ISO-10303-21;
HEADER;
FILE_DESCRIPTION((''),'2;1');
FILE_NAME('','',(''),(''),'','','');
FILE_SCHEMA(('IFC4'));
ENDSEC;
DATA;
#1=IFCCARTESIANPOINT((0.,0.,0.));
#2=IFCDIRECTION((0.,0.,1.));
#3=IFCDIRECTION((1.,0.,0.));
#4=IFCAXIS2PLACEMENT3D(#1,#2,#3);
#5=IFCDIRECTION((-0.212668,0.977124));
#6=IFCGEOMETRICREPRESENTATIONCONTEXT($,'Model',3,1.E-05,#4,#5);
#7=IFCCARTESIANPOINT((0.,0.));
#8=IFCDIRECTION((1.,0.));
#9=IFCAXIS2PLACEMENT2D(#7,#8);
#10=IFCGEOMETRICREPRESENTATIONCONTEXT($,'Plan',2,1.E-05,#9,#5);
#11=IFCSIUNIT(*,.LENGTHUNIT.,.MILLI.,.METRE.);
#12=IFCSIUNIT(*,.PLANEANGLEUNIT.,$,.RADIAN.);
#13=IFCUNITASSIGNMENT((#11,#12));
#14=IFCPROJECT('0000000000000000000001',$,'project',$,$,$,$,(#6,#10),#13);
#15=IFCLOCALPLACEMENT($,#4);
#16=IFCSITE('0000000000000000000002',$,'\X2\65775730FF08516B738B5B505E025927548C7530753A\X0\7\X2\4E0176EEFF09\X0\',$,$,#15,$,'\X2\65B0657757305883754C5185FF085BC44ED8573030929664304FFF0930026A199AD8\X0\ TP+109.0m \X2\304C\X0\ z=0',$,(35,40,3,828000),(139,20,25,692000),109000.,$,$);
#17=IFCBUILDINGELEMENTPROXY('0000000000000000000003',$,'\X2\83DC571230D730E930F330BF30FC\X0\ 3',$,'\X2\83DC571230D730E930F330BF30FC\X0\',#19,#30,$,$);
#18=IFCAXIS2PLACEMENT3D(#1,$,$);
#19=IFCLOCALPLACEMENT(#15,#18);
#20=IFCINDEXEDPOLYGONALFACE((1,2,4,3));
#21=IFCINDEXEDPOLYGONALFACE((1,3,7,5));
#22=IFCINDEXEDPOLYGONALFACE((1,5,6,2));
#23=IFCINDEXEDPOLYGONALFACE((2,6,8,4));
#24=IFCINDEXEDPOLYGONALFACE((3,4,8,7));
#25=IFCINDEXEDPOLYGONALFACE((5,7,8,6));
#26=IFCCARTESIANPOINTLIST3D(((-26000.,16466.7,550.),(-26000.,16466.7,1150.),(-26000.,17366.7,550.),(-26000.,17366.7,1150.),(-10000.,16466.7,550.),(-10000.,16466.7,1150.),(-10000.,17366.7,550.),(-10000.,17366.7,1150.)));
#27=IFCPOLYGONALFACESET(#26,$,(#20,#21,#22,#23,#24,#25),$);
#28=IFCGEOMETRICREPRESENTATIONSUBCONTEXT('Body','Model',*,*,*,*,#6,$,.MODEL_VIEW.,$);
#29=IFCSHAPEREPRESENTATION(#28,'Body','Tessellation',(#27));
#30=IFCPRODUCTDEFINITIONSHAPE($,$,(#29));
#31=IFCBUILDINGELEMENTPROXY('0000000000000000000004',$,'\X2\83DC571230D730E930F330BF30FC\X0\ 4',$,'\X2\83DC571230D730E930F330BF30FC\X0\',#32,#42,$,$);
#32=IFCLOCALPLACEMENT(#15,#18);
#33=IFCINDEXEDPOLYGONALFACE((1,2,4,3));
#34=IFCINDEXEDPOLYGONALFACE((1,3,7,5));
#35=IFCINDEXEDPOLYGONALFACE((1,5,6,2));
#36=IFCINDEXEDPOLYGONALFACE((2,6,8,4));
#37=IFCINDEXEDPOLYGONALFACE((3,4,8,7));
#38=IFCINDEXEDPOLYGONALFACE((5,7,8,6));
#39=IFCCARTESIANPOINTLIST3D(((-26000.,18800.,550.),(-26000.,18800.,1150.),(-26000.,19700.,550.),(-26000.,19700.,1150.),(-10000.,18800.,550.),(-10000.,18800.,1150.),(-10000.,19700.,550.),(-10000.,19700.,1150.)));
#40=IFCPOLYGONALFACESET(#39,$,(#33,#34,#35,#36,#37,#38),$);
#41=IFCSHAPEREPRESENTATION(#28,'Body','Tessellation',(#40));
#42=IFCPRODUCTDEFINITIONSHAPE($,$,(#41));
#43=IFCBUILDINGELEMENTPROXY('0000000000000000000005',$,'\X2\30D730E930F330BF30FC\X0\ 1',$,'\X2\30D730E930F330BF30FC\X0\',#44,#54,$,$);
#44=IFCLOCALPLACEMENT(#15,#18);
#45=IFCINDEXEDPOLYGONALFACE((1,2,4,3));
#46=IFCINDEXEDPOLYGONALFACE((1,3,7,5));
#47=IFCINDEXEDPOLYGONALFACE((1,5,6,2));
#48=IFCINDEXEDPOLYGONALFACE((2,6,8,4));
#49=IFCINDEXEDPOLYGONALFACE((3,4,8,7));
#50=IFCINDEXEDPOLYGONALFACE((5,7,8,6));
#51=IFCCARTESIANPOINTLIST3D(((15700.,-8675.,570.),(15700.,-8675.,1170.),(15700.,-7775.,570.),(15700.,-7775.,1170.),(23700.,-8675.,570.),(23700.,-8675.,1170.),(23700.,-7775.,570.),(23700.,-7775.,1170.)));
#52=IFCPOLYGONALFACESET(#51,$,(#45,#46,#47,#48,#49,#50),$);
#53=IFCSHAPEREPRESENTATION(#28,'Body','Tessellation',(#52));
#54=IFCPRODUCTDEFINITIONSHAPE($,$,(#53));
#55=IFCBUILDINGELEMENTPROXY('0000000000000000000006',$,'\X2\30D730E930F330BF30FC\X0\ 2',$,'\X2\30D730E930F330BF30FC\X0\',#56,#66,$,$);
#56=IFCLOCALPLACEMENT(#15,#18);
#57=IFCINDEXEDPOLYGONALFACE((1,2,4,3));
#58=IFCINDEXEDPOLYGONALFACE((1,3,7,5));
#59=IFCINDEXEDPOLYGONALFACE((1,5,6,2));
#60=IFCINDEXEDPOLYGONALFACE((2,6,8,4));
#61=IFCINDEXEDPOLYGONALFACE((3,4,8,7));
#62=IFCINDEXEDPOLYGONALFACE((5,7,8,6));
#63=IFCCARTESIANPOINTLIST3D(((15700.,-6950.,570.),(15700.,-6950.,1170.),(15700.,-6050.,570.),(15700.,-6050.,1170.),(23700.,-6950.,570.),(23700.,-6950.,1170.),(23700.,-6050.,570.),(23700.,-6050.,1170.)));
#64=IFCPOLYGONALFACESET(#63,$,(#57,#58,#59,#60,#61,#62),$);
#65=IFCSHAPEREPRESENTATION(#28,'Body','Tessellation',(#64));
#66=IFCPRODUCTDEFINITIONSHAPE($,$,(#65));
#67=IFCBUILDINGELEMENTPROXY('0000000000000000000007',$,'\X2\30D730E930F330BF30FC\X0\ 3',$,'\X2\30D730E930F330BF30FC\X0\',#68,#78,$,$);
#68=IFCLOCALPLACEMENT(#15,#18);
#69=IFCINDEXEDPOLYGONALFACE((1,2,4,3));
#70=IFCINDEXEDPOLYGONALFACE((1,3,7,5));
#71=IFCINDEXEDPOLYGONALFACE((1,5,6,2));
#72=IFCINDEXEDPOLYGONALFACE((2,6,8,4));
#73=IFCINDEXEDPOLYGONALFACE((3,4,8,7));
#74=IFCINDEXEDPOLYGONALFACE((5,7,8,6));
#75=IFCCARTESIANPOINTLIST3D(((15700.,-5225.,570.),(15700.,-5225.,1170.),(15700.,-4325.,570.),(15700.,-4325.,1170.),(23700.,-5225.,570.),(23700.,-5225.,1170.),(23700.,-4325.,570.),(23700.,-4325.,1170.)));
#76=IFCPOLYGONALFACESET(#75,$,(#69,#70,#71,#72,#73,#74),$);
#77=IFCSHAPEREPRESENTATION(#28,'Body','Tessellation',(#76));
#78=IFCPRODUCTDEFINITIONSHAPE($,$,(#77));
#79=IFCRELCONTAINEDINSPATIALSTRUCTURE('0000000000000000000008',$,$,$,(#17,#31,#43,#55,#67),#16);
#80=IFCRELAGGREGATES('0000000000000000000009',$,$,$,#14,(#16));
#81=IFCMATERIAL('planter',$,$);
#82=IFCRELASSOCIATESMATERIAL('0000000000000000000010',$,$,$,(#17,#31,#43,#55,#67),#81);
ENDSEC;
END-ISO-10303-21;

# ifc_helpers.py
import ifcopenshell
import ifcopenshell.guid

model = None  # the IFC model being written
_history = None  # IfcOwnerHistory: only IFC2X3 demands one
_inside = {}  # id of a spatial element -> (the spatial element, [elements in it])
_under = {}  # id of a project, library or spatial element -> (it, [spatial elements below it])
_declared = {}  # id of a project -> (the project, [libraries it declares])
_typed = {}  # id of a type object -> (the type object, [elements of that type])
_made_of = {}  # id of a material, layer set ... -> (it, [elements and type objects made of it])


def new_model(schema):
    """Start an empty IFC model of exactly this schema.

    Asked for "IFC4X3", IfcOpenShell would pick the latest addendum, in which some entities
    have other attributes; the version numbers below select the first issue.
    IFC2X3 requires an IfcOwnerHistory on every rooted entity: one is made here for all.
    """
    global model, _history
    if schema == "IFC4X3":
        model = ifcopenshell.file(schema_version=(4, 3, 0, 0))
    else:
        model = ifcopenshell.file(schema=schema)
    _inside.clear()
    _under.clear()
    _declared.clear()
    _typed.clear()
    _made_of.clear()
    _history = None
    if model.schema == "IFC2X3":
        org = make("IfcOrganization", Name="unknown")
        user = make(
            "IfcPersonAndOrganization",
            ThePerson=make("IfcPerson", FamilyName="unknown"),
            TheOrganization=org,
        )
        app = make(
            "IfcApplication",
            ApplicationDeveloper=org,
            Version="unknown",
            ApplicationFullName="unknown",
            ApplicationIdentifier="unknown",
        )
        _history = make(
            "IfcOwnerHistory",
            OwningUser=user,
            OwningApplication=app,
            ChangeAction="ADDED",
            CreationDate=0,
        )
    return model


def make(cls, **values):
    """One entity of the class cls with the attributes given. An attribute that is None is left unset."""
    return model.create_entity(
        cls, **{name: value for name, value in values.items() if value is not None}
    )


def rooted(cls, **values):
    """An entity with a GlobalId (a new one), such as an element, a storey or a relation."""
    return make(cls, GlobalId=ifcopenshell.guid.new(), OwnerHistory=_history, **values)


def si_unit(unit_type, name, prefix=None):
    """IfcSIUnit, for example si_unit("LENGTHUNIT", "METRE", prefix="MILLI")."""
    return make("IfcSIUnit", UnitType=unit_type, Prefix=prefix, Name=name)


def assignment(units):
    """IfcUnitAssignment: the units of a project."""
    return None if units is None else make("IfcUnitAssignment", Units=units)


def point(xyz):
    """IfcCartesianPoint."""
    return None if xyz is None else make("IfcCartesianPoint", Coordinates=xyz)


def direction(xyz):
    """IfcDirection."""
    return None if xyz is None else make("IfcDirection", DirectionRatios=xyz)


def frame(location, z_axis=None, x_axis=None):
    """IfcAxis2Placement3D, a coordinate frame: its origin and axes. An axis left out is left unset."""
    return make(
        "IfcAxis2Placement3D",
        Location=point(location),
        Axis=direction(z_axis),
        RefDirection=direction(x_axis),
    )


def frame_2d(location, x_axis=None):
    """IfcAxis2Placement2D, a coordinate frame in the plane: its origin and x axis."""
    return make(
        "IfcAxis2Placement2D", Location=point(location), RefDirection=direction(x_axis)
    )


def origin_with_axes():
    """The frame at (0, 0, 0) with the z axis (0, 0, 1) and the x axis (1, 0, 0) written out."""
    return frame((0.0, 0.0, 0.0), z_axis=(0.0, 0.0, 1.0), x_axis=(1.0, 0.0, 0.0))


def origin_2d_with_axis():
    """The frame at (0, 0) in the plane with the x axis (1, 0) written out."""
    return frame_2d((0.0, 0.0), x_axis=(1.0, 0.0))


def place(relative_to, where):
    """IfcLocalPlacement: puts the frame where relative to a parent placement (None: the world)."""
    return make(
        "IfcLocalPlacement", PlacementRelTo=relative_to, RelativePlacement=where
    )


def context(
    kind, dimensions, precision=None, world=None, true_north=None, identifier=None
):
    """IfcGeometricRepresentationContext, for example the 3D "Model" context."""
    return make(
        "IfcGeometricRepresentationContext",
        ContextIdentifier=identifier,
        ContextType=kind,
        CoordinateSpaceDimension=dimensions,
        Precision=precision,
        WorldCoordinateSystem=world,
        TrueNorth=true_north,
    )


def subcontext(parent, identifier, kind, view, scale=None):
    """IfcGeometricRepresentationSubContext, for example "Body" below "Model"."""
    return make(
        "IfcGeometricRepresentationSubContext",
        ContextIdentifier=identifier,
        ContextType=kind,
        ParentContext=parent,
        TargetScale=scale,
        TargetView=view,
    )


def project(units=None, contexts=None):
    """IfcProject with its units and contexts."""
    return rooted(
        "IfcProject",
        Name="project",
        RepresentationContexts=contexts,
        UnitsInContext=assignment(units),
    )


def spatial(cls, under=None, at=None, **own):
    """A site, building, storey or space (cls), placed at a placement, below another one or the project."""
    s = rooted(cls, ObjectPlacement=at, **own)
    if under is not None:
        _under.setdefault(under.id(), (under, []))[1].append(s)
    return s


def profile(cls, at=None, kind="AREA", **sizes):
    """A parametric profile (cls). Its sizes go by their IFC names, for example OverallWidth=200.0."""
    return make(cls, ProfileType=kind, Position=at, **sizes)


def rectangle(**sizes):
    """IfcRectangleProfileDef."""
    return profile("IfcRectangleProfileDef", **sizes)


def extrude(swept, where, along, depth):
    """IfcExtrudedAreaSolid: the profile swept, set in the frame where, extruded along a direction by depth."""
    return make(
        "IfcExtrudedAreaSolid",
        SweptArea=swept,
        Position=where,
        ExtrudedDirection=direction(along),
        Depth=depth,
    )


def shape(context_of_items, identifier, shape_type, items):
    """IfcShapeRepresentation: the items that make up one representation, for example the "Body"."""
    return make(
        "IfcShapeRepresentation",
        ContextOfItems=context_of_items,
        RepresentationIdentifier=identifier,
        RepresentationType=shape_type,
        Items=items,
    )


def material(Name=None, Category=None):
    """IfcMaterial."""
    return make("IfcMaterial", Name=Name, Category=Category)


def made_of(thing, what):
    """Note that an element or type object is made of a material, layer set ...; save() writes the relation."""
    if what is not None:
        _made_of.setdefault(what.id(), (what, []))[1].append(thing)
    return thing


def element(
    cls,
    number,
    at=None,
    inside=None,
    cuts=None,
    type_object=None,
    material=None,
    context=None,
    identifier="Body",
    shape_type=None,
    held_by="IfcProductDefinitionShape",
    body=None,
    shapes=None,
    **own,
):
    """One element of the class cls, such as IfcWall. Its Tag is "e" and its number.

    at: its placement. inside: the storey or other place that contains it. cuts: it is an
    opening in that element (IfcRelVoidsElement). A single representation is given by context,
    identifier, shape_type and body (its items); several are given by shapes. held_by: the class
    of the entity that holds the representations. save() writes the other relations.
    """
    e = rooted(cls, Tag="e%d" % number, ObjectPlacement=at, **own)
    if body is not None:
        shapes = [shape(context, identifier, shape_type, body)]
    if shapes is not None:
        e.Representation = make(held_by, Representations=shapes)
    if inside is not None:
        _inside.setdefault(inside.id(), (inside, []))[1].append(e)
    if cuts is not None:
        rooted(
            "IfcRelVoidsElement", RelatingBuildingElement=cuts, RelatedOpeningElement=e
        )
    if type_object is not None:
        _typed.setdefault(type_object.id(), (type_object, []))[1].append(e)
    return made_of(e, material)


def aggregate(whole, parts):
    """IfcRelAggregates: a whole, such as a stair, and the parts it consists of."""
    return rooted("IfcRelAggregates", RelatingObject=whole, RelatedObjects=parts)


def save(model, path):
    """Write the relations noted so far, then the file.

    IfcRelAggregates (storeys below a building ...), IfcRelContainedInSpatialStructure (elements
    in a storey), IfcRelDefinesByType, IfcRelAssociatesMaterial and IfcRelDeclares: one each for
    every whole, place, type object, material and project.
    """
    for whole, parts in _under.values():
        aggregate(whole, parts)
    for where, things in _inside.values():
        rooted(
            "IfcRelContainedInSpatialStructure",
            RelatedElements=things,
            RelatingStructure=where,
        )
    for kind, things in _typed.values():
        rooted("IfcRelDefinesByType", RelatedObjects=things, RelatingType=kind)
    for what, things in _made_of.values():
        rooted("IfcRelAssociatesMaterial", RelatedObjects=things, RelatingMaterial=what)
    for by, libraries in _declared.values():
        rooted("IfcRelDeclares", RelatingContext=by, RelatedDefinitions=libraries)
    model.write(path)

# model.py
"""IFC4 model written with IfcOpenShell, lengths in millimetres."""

from ifc_helpers import new_model, si_unit, direction, frame, frame_2d, origin_with_axes, origin_2d_with_axis, place, context, subcontext, project, spatial, rectangle, extrude, material, element, save


model = new_model("IFC4")

# Units and contexts
model_context = context("Model", 3, precision=1e-05, world=origin_with_axes(), true_north=direction((-0.212668, 0.977124)))
plan_context = context("Plan", 2, precision=1e-05, world=origin_2d_with_axis(), true_north=direction((-0.212668, 0.977124)))
body_context = subcontext(model_context, "Body", "Model", "MODEL_VIEW")
ifc_project = project(units=[si_unit("LENGTHUNIT", "METRE", prefix="MILLI"), si_unit("PLANEANGLEUNIT", "RADIAN")], contexts=[model_context, plan_context])

# Site
site_placement = place(None, origin_with_axes())
site = spatial("IfcSite", under=ifc_project, at=site_placement, Name="敷地（八王子市大和田町7丁目）", LongName="新敷地境界内（寄付地を除く）。標高 TP+109.0m が z=0", RefLatitude=(35, 40, 3, 828000), RefLongitude=(139, 20, 25, 692000), RefElevation=109000.0)

# Building element proxies
ifc_material_1 = material(Name="planter")
proxy_1_placement = place(site_placement, origin_with_axes())
element("IfcBuildingElementProxy", 1, at=proxy_1_placement, inside=site, material=ifc_material_1, Name="菜園プランター 3", ObjectType="菜園プランター", context=body_context, shape_type="SweptSolid", body=[
    extrude(rectangle(XDim=16000.0, YDim=900.0, at=frame_2d((-18000.0, 16916.7))), frame((0.0, 0.0, 550.0)), (0.0, 0.0, 1.0), 600.0),
])
proxy_2_placement = place(site_placement, origin_with_axes())
element("IfcBuildingElementProxy", 2, at=proxy_2_placement, inside=site, material=ifc_material_1, Name="菜園プランター 4", ObjectType="菜園プランター", context=body_context, shape_type="SweptSolid", body=[
    extrude(rectangle(XDim=16000.0, YDim=900.0, at=frame_2d((-18000.0, 19250.0))), frame((0.0, 0.0, 550.0)), (0.0, 0.0, 1.0), 600.0),
])
proxy_3_placement = place(site_placement, origin_with_axes())
element("IfcBuildingElementProxy", 3, at=proxy_3_placement, inside=site, material=ifc_material_1, Name="プランター 1", ObjectType="プランター", context=body_context, shape_type="SweptSolid", body=[
    extrude(rectangle(XDim=8000.0, YDim=900.0, at=frame_2d((19700.0, -8225.0))), frame((0.0, 0.0, 570.0)), (0.0, 0.0, 1.0), 600.0),
])
proxy_4_placement = place(site_placement, origin_with_axes())
element("IfcBuildingElementProxy", 4, at=proxy_4_placement, inside=site, material=ifc_material_1, Name="プランター 2", ObjectType="プランター", context=body_context, shape_type="SweptSolid", body=[
    extrude(rectangle(XDim=8000.0, YDim=900.0, at=frame_2d((19700.0, -6500.0))), frame((0.0, 0.0, 570.0)), (0.0, 0.0, 1.0), 600.0),
])
proxy_5_placement = place(site_placement, origin_with_axes())
element("IfcBuildingElementProxy", 5, at=proxy_5_placement, inside=site, material=ifc_material_1, Name="プランター 3", ObjectType="プランター", context=body_context, shape_type="SweptSolid", body=[
    extrude(rectangle(XDim=8000.0, YDim=900.0, at=frame_2d((19700.0, -4775.0))), frame((0.0, 0.0, 570.0)), (0.0, 0.0, 1.0), 600.0),
])

save(model, "model.ifc")
